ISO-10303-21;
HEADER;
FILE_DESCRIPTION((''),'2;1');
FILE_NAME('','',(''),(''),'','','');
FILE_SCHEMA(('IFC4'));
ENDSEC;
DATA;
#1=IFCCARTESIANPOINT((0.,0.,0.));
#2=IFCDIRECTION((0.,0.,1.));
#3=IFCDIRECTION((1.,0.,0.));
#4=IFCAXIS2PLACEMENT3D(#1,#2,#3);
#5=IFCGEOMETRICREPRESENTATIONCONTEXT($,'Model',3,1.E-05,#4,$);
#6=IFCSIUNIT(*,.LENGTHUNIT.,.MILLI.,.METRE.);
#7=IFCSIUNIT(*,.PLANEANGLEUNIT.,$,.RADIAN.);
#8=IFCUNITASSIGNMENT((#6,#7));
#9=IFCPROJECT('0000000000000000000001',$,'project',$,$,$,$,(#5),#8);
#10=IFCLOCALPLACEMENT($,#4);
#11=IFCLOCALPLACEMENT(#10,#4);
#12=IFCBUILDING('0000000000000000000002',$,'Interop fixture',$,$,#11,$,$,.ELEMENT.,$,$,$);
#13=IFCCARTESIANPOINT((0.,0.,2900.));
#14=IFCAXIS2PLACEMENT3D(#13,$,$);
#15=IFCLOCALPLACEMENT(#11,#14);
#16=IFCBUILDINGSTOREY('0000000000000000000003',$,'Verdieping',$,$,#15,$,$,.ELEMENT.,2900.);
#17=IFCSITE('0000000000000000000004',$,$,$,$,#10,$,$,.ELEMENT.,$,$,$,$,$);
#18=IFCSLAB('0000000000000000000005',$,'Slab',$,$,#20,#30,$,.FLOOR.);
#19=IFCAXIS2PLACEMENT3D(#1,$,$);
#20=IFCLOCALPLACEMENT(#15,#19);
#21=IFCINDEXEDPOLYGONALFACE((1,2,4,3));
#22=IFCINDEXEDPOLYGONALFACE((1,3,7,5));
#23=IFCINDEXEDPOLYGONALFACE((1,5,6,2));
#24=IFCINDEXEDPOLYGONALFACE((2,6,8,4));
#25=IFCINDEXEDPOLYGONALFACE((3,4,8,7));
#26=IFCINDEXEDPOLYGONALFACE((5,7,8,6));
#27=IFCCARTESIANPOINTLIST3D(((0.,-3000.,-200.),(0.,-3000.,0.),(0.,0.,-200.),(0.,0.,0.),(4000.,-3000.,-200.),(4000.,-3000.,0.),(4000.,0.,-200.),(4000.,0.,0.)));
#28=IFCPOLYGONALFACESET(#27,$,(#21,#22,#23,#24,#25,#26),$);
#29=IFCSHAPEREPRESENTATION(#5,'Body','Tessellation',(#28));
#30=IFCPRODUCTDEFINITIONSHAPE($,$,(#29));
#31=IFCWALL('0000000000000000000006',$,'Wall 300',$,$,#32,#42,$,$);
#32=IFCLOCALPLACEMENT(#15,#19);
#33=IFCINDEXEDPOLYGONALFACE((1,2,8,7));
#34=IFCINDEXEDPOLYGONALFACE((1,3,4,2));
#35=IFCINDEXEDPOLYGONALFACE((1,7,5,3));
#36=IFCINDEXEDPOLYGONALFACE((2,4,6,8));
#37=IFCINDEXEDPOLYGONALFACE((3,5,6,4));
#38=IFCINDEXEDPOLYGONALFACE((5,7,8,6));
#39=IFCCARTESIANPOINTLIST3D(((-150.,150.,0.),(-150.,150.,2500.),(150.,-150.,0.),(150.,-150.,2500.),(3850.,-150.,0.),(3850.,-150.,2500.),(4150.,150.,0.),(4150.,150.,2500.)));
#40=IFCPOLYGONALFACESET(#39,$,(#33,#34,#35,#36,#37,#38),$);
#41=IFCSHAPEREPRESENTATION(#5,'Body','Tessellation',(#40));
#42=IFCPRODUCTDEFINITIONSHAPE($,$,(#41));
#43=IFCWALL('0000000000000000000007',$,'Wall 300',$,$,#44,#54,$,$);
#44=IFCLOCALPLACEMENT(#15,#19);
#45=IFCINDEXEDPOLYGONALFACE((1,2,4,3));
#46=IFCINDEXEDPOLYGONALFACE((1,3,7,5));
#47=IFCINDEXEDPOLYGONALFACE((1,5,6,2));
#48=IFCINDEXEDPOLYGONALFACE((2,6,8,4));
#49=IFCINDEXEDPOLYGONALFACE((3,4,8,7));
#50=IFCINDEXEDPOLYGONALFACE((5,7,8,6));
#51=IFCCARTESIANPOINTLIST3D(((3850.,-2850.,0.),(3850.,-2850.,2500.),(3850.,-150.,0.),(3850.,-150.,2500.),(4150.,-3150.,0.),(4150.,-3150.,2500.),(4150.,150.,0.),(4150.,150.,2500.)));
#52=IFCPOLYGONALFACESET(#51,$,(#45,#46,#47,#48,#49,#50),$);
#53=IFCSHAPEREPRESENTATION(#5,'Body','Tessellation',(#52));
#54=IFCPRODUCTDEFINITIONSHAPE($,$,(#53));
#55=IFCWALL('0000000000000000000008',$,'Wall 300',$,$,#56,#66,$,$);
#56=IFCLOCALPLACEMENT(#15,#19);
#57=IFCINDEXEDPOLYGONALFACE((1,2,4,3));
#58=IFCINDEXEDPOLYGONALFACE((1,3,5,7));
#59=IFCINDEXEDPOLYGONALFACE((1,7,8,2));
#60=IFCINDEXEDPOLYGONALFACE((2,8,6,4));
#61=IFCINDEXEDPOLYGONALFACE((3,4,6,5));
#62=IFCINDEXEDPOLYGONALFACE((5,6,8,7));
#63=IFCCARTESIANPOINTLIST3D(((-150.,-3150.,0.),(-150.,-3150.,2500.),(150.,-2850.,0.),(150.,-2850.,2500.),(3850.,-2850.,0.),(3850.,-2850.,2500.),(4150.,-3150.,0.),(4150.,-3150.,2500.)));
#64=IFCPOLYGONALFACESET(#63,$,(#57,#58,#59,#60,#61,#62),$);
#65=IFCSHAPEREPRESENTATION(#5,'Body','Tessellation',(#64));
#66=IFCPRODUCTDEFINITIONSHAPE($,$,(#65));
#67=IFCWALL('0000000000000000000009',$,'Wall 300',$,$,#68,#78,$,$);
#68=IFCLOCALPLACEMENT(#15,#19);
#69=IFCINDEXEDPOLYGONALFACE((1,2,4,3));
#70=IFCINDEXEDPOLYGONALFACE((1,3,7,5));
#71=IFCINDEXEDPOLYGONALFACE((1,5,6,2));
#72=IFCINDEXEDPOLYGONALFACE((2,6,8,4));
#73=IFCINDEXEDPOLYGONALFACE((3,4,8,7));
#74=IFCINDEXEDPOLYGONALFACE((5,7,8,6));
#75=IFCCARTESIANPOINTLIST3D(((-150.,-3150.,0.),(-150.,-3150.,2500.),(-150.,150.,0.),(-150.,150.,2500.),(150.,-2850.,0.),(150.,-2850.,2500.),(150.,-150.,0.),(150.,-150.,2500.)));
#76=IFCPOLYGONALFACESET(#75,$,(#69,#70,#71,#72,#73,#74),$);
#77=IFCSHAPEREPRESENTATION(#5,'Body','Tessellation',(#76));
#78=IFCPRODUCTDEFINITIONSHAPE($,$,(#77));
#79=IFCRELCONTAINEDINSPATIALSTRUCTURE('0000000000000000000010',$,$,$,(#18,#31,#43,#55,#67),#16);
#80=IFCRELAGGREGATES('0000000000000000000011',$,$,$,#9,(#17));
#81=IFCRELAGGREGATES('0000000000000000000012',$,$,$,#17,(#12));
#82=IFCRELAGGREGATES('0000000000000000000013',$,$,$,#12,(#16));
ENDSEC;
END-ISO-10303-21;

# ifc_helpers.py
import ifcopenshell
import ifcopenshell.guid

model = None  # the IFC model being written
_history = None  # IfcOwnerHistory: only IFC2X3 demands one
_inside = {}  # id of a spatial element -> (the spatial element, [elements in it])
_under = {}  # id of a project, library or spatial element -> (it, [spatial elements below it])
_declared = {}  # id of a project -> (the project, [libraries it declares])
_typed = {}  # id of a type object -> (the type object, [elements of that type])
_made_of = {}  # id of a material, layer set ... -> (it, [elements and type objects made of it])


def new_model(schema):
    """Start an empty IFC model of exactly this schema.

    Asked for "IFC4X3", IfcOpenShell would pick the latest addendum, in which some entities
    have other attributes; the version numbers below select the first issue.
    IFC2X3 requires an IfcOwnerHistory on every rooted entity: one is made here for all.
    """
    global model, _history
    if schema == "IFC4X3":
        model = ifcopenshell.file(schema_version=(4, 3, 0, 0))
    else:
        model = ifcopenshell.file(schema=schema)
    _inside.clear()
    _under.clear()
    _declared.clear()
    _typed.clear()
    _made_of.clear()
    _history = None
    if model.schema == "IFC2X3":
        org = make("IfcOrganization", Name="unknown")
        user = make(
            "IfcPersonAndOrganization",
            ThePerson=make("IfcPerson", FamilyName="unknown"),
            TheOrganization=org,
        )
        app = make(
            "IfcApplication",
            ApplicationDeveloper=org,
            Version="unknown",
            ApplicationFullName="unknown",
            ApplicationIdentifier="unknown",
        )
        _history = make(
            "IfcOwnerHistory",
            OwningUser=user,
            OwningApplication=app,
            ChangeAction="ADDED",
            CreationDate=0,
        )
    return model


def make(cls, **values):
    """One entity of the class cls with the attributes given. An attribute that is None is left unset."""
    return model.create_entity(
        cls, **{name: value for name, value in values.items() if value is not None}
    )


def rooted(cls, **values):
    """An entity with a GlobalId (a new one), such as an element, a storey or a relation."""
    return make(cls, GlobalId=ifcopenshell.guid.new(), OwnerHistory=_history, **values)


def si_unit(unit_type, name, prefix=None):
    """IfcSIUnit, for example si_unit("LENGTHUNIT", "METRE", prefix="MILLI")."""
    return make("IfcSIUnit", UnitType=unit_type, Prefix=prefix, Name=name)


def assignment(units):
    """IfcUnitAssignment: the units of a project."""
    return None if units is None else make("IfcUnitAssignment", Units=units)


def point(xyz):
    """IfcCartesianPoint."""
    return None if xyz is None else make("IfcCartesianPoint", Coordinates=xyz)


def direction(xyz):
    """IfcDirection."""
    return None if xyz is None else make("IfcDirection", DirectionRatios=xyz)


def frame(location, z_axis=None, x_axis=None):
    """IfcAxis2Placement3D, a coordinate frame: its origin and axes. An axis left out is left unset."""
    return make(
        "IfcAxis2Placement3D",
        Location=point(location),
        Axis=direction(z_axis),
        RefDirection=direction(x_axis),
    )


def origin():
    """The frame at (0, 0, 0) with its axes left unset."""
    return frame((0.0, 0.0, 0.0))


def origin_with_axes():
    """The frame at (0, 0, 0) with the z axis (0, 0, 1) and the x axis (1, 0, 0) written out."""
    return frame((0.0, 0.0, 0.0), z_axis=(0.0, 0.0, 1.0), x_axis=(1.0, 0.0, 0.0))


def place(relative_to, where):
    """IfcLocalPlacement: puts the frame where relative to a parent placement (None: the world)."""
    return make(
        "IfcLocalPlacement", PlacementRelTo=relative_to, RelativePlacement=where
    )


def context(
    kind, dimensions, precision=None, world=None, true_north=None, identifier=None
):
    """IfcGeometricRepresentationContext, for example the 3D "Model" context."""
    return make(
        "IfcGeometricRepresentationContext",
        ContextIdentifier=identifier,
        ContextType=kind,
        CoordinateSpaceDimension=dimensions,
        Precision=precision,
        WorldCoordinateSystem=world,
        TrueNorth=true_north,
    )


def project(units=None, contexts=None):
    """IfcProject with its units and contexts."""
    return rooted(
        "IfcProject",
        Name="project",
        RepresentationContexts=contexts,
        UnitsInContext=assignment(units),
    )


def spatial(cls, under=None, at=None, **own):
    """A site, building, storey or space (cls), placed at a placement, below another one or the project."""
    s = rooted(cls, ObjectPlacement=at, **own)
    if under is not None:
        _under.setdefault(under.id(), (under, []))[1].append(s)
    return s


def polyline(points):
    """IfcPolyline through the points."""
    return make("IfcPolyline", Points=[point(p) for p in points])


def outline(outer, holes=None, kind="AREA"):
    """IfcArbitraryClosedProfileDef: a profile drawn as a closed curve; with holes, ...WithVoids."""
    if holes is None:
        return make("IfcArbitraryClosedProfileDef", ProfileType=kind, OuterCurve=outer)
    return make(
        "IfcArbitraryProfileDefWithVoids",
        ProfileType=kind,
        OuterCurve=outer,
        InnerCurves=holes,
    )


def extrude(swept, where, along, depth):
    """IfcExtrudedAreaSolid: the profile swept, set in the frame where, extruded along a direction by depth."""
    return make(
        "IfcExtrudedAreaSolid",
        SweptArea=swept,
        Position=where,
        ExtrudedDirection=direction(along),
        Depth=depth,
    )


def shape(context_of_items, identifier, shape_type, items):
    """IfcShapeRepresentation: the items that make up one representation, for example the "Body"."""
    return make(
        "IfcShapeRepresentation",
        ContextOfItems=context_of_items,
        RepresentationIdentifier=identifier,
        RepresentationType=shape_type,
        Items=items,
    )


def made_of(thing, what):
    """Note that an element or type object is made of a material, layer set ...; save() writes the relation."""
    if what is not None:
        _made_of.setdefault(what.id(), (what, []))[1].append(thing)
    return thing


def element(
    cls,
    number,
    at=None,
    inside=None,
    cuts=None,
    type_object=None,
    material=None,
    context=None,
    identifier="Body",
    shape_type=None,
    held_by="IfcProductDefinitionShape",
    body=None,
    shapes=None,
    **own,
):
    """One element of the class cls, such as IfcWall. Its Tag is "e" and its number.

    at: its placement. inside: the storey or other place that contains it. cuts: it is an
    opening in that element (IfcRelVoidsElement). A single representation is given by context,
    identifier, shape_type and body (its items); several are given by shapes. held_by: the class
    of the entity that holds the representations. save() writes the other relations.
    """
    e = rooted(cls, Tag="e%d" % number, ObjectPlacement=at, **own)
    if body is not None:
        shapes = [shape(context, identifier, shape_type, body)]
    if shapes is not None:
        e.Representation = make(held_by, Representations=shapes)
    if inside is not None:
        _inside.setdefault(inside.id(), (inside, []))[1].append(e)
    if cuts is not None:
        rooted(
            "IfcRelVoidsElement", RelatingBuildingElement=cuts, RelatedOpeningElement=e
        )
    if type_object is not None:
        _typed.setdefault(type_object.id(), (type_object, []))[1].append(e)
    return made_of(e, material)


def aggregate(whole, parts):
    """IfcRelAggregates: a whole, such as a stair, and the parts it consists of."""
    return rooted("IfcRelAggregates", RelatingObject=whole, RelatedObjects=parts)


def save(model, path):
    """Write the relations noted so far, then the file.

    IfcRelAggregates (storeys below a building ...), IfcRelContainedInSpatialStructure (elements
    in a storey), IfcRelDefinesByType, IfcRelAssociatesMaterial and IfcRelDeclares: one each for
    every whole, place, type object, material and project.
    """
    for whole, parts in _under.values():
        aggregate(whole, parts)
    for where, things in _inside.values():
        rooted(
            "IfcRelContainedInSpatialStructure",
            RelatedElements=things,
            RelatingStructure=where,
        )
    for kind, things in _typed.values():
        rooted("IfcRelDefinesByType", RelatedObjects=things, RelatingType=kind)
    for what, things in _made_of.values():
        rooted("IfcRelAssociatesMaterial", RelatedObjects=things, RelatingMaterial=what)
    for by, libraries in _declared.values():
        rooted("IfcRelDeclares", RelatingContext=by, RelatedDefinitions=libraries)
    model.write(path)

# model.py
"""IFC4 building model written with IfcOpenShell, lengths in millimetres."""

from ifc_helpers import new_model, si_unit, frame, origin, origin_with_axes, place, context, project, spatial, polyline, outline, extrude, element, save


model = new_model("IFC4")

# Units and contexts
model_context = context("Model", 3, precision=1e-05, world=origin_with_axes())
ifc_project = project(units=[si_unit("LENGTHUNIT", "METRE", prefix="MILLI"), si_unit("PLANEANGLEUNIT", "RADIAN")], contexts=[model_context])

# Site, building, storey
site_placement = place(None, origin_with_axes())
site = spatial("IfcSite", under=ifc_project, at=site_placement, CompositionType="ELEMENT")
building_placement = place(site_placement, origin_with_axes())
building = spatial("IfcBuilding", under=site, at=building_placement, Name="Interop fixture", CompositionType="ELEMENT")
storey_placement = place(building_placement, frame((0.0, 0.0, 2900.0)))
storey = spatial("IfcBuildingStorey", under=building, at=storey_placement, Name="Verdieping", CompositionType="ELEMENT", Elevation=2900.0)

# Slab
placement = place(storey_placement, origin_with_axes())
element("IfcSlab", 1, at=placement, inside=storey, Name="Slab", PredefinedType="FLOOR", context=model_context, shape_type="SweptSolid", body=[
    extrude(outline(polyline([(4000.0, 0.0), (0.0, 0.0), (0.0, -3000.0), (4000.0, -3000.0), (4000.0, 0.0)])), frame((0.0, 0.0, -200.0)), (0.0, 0.0, 1.0), 200.0),
])

# Walls
element("IfcWall", 2, at=placement, inside=storey, Name="Wall 300", context=model_context, shape_type="SweptSolid", body=[
    extrude(outline(polyline([(150.0, -150.0), (3850.0, -150.0), (4150.0, 150.0), (-150.0, 150.0), (150.0, -150.0)])), origin(), (0.0, 0.0, 1.0), 2500.0),
])
element("IfcWall", 3, at=placement, inside=storey, Name="Wall 300", context=model_context, shape_type="SweptSolid", body=[
    extrude(outline(polyline([(3850.0, -150.0), (3850.0, -2850.0), (4150.0, -3150.0), (4150.0, 150.0), (3850.0, -150.0)])), origin(), (0.0, 0.0, 1.0), 2500.0),
])
element("IfcWall", 4, at=placement, inside=storey, Name="Wall 300", context=model_context, shape_type="SweptSolid", body=[
    extrude(outline(polyline([(3850.0, -2850.0), (150.0, -2850.0), (-150.0, -3150.0), (4150.0, -3150.0), (3850.0, -2850.0)])), origin(), (0.0, 0.0, 1.0), 2500.0),
])
element("IfcWall", 5, at=placement, inside=storey, Name="Wall 300", context=model_context, shape_type="SweptSolid", body=[
    extrude(outline(polyline([(150.0, -2850.0), (150.0, -150.0), (-150.0, 150.0), (-150.0, -3150.0), (150.0, -2850.0)])), origin(), (0.0, 0.0, 1.0), 2500.0),
])

save(model, "model.ifc")
